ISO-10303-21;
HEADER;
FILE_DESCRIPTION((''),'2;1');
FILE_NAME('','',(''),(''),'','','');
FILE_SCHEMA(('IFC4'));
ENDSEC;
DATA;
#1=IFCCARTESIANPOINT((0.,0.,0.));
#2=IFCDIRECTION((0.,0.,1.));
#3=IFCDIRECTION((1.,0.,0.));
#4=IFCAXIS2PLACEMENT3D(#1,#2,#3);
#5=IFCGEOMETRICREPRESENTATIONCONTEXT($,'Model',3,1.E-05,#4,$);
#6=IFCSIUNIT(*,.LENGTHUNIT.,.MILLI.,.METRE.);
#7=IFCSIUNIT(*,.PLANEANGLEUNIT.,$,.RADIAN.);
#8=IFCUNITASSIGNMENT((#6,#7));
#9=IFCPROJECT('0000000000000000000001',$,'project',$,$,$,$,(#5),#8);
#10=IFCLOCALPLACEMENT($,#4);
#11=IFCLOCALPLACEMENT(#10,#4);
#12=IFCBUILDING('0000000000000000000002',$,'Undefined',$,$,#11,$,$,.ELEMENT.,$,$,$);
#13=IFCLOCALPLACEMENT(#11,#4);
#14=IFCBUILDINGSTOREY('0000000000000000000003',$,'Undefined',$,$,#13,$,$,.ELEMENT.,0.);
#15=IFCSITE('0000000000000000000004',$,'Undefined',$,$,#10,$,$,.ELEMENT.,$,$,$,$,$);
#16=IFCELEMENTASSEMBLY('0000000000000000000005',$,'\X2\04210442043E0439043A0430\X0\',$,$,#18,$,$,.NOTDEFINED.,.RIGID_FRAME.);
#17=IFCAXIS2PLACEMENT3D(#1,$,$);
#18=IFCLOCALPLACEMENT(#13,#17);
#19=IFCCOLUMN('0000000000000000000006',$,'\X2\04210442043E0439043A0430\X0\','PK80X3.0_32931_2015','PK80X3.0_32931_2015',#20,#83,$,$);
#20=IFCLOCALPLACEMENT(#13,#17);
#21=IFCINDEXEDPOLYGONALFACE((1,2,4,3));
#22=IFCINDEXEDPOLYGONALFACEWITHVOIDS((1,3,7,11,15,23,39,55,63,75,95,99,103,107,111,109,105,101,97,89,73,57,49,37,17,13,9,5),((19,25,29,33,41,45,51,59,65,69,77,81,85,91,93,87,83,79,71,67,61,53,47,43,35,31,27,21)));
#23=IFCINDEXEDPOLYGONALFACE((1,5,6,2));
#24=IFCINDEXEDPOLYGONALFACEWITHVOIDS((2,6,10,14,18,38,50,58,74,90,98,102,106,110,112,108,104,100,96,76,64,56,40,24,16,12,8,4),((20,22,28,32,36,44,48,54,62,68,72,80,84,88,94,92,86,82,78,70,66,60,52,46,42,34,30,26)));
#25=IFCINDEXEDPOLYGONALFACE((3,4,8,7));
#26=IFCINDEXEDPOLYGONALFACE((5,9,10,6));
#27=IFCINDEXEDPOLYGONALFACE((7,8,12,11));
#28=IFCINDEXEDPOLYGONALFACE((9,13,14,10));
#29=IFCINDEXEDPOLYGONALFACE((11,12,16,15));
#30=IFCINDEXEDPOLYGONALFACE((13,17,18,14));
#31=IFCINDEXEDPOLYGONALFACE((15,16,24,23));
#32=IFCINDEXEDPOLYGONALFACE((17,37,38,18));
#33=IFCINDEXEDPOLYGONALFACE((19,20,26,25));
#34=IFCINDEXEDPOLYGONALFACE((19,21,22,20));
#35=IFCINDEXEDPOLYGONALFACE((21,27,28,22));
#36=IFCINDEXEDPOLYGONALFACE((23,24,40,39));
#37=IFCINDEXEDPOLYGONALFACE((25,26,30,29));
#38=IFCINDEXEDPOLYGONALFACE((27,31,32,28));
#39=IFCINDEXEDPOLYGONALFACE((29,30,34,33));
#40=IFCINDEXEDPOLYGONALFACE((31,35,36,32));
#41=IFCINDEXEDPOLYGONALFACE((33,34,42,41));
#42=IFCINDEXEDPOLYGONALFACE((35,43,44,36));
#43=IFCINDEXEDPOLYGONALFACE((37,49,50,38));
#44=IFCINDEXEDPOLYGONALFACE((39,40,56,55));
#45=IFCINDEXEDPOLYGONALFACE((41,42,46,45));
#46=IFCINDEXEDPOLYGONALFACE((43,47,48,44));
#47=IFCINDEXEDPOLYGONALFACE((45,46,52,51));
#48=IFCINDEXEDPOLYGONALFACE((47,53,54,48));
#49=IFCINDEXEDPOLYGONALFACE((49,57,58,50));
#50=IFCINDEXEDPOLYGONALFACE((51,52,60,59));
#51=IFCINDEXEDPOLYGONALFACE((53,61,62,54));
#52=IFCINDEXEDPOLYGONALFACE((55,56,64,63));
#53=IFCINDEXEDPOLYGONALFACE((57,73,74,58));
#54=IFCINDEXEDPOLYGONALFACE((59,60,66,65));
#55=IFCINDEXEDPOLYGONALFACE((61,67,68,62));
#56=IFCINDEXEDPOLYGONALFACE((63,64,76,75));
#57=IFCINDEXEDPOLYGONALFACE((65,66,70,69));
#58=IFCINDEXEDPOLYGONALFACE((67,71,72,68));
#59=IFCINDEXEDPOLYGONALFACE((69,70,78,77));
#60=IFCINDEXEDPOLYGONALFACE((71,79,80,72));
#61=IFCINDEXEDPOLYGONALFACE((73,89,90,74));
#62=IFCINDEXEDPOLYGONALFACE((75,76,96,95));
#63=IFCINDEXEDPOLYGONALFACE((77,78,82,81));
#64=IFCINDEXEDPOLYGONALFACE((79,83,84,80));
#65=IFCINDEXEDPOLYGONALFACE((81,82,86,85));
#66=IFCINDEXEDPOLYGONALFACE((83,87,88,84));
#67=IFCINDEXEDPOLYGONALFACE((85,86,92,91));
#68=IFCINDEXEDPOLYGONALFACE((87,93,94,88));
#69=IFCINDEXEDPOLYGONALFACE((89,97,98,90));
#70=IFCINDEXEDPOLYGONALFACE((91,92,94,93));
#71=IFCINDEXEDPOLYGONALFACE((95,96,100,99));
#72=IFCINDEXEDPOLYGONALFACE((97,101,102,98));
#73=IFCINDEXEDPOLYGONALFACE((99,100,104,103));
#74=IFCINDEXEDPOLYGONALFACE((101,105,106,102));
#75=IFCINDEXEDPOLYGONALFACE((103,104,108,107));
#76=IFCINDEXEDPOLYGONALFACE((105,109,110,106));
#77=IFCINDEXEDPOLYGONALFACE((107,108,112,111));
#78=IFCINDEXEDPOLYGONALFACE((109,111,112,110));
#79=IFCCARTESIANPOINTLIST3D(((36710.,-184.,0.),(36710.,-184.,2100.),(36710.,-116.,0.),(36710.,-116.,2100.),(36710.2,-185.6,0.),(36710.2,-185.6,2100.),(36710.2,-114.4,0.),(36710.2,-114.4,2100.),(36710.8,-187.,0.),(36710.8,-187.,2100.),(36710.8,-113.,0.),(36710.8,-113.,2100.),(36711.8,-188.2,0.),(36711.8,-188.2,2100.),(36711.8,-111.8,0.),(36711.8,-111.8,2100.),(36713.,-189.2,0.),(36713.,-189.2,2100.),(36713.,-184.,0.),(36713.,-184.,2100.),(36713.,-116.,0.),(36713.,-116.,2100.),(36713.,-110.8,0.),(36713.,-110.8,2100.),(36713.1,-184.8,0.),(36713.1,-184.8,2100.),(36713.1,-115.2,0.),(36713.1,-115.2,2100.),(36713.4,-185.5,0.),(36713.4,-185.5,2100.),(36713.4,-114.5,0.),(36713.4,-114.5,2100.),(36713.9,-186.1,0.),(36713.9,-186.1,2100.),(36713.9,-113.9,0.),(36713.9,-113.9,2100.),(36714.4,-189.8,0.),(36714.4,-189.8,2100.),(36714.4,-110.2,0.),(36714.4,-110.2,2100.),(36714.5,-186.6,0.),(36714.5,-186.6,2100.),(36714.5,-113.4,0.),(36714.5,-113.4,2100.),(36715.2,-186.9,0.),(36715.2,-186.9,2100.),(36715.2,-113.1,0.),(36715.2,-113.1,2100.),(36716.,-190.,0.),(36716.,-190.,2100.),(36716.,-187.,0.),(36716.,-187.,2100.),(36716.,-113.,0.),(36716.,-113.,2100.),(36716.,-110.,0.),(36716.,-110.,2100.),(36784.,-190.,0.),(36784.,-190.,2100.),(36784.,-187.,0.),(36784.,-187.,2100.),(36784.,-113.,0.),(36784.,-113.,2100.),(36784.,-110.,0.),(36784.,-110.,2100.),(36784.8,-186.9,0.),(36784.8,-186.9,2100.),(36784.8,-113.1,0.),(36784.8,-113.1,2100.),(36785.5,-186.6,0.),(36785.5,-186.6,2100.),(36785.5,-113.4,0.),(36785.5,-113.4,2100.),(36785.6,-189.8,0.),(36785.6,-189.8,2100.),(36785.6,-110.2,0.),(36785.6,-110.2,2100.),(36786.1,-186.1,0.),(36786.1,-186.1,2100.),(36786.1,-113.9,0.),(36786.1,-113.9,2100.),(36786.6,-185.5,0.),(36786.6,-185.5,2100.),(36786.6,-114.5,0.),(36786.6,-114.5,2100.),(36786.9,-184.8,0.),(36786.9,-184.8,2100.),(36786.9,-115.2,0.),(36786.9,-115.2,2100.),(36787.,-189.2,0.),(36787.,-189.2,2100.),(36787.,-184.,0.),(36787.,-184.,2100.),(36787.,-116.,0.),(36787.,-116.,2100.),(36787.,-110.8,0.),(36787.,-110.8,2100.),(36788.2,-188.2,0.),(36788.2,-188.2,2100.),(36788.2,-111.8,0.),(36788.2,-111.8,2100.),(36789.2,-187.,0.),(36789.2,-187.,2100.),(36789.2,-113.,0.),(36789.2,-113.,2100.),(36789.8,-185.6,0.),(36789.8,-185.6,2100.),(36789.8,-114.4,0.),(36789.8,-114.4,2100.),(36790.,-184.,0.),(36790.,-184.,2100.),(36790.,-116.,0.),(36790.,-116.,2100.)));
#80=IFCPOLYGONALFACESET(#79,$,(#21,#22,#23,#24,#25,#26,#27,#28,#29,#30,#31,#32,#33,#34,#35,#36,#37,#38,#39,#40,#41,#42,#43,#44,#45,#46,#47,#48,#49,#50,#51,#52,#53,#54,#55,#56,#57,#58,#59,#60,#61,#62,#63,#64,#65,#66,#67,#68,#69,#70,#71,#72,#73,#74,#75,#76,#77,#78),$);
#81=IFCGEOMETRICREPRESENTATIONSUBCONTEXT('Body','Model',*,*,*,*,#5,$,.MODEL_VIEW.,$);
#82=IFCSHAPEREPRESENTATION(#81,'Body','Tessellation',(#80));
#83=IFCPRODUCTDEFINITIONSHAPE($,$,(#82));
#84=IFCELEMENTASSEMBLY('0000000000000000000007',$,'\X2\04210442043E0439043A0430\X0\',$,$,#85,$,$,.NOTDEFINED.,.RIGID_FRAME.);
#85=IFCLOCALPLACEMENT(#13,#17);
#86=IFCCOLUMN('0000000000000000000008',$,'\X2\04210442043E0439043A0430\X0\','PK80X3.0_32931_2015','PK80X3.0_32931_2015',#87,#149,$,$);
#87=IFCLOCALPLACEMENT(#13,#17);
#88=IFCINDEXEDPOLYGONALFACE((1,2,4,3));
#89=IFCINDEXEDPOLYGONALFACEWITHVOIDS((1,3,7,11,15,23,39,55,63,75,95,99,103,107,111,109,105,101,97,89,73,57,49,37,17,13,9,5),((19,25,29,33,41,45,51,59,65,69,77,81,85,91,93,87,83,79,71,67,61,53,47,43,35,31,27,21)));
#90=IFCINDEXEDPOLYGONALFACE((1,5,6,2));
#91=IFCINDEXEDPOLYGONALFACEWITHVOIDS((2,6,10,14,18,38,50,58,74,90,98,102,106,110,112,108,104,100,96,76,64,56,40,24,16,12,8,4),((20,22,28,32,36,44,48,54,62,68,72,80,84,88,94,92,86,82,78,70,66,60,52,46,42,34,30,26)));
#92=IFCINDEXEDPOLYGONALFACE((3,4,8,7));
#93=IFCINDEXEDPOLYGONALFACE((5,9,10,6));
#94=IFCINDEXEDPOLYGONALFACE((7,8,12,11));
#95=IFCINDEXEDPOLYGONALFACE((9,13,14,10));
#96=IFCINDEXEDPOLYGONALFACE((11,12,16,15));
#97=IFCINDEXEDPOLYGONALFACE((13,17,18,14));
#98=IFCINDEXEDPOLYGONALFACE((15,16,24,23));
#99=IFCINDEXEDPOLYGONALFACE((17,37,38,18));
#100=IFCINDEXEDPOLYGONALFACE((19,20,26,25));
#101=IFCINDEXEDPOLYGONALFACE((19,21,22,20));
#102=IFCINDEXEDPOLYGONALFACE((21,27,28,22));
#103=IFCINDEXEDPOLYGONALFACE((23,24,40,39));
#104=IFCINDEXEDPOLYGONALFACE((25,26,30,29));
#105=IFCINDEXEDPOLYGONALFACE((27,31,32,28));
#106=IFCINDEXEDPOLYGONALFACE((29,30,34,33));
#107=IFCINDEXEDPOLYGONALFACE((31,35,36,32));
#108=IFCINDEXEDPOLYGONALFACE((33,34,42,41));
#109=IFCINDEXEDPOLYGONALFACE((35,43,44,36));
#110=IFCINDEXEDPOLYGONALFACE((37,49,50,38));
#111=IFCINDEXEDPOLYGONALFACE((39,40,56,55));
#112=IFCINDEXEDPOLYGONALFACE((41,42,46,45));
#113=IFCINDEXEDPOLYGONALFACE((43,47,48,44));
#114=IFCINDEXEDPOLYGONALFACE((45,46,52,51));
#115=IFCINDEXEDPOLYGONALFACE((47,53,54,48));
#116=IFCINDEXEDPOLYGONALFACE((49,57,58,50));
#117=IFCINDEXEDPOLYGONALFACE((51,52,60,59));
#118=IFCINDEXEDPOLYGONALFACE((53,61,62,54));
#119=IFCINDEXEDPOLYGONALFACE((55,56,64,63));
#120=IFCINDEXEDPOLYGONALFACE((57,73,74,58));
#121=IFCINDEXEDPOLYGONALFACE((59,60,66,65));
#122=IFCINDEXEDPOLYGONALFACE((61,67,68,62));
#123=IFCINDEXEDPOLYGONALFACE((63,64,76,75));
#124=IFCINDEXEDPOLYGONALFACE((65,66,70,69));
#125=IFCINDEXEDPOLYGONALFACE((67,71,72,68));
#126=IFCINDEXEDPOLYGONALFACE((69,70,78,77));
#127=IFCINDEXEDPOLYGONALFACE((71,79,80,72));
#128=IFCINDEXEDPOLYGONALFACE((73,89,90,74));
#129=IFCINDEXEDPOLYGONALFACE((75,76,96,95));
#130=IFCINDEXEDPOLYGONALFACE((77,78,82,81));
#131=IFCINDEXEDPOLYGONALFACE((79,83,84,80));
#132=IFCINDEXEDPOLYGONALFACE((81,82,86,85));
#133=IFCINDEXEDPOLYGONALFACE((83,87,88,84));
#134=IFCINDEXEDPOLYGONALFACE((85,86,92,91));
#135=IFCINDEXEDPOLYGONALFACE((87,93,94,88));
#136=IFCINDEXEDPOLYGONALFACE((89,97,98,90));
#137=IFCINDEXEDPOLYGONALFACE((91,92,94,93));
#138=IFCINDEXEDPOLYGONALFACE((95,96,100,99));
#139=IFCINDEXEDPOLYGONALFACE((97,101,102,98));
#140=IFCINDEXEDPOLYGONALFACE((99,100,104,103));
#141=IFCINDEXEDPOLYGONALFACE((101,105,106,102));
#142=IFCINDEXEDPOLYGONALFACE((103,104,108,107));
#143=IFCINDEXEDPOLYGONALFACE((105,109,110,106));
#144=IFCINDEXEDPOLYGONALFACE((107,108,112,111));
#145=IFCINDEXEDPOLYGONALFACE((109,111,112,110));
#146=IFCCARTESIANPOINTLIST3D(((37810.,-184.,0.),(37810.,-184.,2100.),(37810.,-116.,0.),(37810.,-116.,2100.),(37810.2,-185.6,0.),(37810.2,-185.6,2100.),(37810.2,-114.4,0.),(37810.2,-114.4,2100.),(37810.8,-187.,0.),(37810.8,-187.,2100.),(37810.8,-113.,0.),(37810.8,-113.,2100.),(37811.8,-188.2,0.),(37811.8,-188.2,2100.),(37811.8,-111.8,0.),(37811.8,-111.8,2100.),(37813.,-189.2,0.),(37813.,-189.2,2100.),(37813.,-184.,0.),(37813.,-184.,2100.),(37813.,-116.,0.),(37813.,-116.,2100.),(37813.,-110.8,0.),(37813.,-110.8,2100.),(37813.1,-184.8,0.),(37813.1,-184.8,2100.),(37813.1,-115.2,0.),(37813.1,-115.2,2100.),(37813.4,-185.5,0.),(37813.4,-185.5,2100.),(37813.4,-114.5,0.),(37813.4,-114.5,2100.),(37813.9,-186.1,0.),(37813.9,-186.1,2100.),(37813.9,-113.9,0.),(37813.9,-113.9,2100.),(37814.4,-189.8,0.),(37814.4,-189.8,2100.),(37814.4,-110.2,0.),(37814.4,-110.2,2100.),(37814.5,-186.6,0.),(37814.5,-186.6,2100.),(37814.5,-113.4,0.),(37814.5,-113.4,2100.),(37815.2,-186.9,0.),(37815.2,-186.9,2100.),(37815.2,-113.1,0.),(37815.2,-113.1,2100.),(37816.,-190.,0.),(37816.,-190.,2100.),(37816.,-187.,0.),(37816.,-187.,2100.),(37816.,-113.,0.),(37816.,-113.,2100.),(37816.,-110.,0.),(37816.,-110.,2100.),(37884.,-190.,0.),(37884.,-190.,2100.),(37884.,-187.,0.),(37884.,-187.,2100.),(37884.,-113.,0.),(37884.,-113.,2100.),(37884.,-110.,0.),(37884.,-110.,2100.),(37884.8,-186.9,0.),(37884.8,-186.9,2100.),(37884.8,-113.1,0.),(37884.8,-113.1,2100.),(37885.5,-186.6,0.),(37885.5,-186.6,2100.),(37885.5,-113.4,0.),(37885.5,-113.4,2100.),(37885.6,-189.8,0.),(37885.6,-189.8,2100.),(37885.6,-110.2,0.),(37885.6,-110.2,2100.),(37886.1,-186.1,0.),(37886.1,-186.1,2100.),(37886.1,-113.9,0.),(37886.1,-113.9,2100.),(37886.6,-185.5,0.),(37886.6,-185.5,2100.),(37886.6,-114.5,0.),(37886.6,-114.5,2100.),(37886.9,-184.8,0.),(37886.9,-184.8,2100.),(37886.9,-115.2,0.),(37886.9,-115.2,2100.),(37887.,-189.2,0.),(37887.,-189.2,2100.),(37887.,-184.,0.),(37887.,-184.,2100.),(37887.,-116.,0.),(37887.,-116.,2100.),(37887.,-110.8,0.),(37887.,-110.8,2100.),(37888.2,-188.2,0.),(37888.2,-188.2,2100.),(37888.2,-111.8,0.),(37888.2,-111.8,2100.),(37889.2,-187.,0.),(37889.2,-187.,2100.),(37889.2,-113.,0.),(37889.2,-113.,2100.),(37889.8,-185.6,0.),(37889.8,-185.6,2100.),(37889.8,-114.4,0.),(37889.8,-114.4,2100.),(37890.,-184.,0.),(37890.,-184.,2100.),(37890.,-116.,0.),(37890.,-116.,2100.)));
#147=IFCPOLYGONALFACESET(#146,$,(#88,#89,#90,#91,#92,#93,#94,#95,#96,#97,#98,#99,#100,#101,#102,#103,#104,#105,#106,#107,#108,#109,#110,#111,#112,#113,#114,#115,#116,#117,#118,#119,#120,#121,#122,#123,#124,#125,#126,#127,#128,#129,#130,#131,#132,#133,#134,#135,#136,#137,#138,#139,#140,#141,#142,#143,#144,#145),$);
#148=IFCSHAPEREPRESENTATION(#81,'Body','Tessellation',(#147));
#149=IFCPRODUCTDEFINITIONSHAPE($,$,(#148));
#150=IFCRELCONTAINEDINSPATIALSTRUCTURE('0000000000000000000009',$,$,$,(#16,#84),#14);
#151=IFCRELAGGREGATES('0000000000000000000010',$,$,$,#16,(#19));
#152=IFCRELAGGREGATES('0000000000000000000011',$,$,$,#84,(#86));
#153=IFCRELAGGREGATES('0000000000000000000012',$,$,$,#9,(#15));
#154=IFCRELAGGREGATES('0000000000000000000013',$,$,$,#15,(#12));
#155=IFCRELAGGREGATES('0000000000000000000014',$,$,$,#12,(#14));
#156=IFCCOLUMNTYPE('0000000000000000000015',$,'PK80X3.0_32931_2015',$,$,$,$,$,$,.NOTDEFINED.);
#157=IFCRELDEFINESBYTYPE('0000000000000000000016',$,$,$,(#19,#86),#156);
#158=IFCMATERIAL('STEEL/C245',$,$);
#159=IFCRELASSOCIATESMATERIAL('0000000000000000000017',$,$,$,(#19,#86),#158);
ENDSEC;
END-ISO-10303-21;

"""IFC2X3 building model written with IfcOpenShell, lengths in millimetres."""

from ifc_helpers import new_model, si_unit, frame, origin_with_axes, origin_2d_with_axis, place, context, subcontext, project, spatial, hollow_rectangle, extrude, material, type_object, element, aggregate, save


model = new_model("IFC2X3")

# Units and contexts
model_context = context("Model", 3, precision=1e-05, world=origin_with_axes())
body_context = subcontext(model_context, "Body", "Model", "MODEL_VIEW")
ifc_project = project(units=[si_unit("LENGTHUNIT", "METRE", prefix="MILLI"), si_unit("PLANEANGLEUNIT", "RADIAN")], contexts=[model_context])

# Site, building, storey
site_placement = place(None, origin_with_axes())
site = spatial("IfcSite", under=ifc_project, at=site_placement, Name="Undefined", CompositionType="ELEMENT")
building_placement = place(site_placement, origin_with_axes())
building = spatial("IfcBuilding", under=site, at=building_placement, Name="Undefined", CompositionType="ELEMENT")
storey_placement = place(building_placement, origin_with_axes())
storey = spatial("IfcBuildingStorey", under=building, at=storey_placement, Name="Undefined", CompositionType="ELEMENT", Elevation=0.0)

# Element assemblies, columns
assembly_1_placement = place(storey_placement, origin_with_axes())
assembly_1 = element("IfcElementAssembly", 1, at=assembly_1_placement, inside=storey, Name="Стойка", AssemblyPlace="NOTDEFINED", PredefinedType="RIGID_FRAME")
ifc_material_1 = material(Name="STEEL/C245")
column_type_1 = type_object("IfcColumnType", Name="PK80X3.0_32931_2015", PredefinedType="NOTDEFINED")
column_1_placement = place(assembly_1_placement, frame((36750.0, -150.0, 0.0), z_axis=(0.0, 0.0, 1.0), x_axis=(0.0, 1.0, 0.0)))
column_1 = element("IfcColumn", 2, at=column_1_placement, type_object=column_type_1, material=ifc_material_1, Name="Стойка", Description="PK80X3.0_32931_2015", ObjectType="PK80X3.0_32931_2015", context=body_context, shape_type="SweptSolid", body=[
    extrude(hollow_rectangle(XDim=80.0, YDim=80.0, WallThickness=3.0, InnerFilletRadius=3.0, OuterFilletRadius=6.0, at=origin_2d_with_axis()), frame((0.0, 0.0, 2100.0), z_axis=(0.0, 0.0, -1.0), x_axis=(0.0, 1.0, 0.0)), (0.0, 0.0, 1.0), 2100.0),
])
aggregate(assembly_1, [column_1])
assembly_2_placement = place(storey_placement, origin_with_axes())
assembly_2 = element("IfcElementAssembly", 3, at=assembly_2_placement, inside=storey, Name="Стойка", AssemblyPlace="NOTDEFINED", PredefinedType="RIGID_FRAME")
column_2_placement = place(assembly_2_placement, frame((37850.0, -150.0, 0.0), z_axis=(0.0, 0.0, 1.0), x_axis=(0.0, 1.0, 0.0)))
column_2 = element("IfcColumn", 4, at=column_2_placement, type_object=column_type_1, material=ifc_material_1, Name="Стойка", Description="PK80X3.0_32931_2015", ObjectType="PK80X3.0_32931_2015", context=body_context, shape_type="SweptSolid", body=[
    extrude(hollow_rectangle(XDim=80.0, YDim=80.0, WallThickness=3.0, InnerFilletRadius=3.0, OuterFilletRadius=6.0, at=origin_2d_with_axis()), frame((0.0, 0.0, 2100.0), z_axis=(0.0, 0.0, -1.0), x_axis=(0.0, 1.0, 0.0)), (0.0, 0.0, 1.0), 2100.0),
])
aggregate(assembly_2, [column_2])

save(model, "model.ifc")
